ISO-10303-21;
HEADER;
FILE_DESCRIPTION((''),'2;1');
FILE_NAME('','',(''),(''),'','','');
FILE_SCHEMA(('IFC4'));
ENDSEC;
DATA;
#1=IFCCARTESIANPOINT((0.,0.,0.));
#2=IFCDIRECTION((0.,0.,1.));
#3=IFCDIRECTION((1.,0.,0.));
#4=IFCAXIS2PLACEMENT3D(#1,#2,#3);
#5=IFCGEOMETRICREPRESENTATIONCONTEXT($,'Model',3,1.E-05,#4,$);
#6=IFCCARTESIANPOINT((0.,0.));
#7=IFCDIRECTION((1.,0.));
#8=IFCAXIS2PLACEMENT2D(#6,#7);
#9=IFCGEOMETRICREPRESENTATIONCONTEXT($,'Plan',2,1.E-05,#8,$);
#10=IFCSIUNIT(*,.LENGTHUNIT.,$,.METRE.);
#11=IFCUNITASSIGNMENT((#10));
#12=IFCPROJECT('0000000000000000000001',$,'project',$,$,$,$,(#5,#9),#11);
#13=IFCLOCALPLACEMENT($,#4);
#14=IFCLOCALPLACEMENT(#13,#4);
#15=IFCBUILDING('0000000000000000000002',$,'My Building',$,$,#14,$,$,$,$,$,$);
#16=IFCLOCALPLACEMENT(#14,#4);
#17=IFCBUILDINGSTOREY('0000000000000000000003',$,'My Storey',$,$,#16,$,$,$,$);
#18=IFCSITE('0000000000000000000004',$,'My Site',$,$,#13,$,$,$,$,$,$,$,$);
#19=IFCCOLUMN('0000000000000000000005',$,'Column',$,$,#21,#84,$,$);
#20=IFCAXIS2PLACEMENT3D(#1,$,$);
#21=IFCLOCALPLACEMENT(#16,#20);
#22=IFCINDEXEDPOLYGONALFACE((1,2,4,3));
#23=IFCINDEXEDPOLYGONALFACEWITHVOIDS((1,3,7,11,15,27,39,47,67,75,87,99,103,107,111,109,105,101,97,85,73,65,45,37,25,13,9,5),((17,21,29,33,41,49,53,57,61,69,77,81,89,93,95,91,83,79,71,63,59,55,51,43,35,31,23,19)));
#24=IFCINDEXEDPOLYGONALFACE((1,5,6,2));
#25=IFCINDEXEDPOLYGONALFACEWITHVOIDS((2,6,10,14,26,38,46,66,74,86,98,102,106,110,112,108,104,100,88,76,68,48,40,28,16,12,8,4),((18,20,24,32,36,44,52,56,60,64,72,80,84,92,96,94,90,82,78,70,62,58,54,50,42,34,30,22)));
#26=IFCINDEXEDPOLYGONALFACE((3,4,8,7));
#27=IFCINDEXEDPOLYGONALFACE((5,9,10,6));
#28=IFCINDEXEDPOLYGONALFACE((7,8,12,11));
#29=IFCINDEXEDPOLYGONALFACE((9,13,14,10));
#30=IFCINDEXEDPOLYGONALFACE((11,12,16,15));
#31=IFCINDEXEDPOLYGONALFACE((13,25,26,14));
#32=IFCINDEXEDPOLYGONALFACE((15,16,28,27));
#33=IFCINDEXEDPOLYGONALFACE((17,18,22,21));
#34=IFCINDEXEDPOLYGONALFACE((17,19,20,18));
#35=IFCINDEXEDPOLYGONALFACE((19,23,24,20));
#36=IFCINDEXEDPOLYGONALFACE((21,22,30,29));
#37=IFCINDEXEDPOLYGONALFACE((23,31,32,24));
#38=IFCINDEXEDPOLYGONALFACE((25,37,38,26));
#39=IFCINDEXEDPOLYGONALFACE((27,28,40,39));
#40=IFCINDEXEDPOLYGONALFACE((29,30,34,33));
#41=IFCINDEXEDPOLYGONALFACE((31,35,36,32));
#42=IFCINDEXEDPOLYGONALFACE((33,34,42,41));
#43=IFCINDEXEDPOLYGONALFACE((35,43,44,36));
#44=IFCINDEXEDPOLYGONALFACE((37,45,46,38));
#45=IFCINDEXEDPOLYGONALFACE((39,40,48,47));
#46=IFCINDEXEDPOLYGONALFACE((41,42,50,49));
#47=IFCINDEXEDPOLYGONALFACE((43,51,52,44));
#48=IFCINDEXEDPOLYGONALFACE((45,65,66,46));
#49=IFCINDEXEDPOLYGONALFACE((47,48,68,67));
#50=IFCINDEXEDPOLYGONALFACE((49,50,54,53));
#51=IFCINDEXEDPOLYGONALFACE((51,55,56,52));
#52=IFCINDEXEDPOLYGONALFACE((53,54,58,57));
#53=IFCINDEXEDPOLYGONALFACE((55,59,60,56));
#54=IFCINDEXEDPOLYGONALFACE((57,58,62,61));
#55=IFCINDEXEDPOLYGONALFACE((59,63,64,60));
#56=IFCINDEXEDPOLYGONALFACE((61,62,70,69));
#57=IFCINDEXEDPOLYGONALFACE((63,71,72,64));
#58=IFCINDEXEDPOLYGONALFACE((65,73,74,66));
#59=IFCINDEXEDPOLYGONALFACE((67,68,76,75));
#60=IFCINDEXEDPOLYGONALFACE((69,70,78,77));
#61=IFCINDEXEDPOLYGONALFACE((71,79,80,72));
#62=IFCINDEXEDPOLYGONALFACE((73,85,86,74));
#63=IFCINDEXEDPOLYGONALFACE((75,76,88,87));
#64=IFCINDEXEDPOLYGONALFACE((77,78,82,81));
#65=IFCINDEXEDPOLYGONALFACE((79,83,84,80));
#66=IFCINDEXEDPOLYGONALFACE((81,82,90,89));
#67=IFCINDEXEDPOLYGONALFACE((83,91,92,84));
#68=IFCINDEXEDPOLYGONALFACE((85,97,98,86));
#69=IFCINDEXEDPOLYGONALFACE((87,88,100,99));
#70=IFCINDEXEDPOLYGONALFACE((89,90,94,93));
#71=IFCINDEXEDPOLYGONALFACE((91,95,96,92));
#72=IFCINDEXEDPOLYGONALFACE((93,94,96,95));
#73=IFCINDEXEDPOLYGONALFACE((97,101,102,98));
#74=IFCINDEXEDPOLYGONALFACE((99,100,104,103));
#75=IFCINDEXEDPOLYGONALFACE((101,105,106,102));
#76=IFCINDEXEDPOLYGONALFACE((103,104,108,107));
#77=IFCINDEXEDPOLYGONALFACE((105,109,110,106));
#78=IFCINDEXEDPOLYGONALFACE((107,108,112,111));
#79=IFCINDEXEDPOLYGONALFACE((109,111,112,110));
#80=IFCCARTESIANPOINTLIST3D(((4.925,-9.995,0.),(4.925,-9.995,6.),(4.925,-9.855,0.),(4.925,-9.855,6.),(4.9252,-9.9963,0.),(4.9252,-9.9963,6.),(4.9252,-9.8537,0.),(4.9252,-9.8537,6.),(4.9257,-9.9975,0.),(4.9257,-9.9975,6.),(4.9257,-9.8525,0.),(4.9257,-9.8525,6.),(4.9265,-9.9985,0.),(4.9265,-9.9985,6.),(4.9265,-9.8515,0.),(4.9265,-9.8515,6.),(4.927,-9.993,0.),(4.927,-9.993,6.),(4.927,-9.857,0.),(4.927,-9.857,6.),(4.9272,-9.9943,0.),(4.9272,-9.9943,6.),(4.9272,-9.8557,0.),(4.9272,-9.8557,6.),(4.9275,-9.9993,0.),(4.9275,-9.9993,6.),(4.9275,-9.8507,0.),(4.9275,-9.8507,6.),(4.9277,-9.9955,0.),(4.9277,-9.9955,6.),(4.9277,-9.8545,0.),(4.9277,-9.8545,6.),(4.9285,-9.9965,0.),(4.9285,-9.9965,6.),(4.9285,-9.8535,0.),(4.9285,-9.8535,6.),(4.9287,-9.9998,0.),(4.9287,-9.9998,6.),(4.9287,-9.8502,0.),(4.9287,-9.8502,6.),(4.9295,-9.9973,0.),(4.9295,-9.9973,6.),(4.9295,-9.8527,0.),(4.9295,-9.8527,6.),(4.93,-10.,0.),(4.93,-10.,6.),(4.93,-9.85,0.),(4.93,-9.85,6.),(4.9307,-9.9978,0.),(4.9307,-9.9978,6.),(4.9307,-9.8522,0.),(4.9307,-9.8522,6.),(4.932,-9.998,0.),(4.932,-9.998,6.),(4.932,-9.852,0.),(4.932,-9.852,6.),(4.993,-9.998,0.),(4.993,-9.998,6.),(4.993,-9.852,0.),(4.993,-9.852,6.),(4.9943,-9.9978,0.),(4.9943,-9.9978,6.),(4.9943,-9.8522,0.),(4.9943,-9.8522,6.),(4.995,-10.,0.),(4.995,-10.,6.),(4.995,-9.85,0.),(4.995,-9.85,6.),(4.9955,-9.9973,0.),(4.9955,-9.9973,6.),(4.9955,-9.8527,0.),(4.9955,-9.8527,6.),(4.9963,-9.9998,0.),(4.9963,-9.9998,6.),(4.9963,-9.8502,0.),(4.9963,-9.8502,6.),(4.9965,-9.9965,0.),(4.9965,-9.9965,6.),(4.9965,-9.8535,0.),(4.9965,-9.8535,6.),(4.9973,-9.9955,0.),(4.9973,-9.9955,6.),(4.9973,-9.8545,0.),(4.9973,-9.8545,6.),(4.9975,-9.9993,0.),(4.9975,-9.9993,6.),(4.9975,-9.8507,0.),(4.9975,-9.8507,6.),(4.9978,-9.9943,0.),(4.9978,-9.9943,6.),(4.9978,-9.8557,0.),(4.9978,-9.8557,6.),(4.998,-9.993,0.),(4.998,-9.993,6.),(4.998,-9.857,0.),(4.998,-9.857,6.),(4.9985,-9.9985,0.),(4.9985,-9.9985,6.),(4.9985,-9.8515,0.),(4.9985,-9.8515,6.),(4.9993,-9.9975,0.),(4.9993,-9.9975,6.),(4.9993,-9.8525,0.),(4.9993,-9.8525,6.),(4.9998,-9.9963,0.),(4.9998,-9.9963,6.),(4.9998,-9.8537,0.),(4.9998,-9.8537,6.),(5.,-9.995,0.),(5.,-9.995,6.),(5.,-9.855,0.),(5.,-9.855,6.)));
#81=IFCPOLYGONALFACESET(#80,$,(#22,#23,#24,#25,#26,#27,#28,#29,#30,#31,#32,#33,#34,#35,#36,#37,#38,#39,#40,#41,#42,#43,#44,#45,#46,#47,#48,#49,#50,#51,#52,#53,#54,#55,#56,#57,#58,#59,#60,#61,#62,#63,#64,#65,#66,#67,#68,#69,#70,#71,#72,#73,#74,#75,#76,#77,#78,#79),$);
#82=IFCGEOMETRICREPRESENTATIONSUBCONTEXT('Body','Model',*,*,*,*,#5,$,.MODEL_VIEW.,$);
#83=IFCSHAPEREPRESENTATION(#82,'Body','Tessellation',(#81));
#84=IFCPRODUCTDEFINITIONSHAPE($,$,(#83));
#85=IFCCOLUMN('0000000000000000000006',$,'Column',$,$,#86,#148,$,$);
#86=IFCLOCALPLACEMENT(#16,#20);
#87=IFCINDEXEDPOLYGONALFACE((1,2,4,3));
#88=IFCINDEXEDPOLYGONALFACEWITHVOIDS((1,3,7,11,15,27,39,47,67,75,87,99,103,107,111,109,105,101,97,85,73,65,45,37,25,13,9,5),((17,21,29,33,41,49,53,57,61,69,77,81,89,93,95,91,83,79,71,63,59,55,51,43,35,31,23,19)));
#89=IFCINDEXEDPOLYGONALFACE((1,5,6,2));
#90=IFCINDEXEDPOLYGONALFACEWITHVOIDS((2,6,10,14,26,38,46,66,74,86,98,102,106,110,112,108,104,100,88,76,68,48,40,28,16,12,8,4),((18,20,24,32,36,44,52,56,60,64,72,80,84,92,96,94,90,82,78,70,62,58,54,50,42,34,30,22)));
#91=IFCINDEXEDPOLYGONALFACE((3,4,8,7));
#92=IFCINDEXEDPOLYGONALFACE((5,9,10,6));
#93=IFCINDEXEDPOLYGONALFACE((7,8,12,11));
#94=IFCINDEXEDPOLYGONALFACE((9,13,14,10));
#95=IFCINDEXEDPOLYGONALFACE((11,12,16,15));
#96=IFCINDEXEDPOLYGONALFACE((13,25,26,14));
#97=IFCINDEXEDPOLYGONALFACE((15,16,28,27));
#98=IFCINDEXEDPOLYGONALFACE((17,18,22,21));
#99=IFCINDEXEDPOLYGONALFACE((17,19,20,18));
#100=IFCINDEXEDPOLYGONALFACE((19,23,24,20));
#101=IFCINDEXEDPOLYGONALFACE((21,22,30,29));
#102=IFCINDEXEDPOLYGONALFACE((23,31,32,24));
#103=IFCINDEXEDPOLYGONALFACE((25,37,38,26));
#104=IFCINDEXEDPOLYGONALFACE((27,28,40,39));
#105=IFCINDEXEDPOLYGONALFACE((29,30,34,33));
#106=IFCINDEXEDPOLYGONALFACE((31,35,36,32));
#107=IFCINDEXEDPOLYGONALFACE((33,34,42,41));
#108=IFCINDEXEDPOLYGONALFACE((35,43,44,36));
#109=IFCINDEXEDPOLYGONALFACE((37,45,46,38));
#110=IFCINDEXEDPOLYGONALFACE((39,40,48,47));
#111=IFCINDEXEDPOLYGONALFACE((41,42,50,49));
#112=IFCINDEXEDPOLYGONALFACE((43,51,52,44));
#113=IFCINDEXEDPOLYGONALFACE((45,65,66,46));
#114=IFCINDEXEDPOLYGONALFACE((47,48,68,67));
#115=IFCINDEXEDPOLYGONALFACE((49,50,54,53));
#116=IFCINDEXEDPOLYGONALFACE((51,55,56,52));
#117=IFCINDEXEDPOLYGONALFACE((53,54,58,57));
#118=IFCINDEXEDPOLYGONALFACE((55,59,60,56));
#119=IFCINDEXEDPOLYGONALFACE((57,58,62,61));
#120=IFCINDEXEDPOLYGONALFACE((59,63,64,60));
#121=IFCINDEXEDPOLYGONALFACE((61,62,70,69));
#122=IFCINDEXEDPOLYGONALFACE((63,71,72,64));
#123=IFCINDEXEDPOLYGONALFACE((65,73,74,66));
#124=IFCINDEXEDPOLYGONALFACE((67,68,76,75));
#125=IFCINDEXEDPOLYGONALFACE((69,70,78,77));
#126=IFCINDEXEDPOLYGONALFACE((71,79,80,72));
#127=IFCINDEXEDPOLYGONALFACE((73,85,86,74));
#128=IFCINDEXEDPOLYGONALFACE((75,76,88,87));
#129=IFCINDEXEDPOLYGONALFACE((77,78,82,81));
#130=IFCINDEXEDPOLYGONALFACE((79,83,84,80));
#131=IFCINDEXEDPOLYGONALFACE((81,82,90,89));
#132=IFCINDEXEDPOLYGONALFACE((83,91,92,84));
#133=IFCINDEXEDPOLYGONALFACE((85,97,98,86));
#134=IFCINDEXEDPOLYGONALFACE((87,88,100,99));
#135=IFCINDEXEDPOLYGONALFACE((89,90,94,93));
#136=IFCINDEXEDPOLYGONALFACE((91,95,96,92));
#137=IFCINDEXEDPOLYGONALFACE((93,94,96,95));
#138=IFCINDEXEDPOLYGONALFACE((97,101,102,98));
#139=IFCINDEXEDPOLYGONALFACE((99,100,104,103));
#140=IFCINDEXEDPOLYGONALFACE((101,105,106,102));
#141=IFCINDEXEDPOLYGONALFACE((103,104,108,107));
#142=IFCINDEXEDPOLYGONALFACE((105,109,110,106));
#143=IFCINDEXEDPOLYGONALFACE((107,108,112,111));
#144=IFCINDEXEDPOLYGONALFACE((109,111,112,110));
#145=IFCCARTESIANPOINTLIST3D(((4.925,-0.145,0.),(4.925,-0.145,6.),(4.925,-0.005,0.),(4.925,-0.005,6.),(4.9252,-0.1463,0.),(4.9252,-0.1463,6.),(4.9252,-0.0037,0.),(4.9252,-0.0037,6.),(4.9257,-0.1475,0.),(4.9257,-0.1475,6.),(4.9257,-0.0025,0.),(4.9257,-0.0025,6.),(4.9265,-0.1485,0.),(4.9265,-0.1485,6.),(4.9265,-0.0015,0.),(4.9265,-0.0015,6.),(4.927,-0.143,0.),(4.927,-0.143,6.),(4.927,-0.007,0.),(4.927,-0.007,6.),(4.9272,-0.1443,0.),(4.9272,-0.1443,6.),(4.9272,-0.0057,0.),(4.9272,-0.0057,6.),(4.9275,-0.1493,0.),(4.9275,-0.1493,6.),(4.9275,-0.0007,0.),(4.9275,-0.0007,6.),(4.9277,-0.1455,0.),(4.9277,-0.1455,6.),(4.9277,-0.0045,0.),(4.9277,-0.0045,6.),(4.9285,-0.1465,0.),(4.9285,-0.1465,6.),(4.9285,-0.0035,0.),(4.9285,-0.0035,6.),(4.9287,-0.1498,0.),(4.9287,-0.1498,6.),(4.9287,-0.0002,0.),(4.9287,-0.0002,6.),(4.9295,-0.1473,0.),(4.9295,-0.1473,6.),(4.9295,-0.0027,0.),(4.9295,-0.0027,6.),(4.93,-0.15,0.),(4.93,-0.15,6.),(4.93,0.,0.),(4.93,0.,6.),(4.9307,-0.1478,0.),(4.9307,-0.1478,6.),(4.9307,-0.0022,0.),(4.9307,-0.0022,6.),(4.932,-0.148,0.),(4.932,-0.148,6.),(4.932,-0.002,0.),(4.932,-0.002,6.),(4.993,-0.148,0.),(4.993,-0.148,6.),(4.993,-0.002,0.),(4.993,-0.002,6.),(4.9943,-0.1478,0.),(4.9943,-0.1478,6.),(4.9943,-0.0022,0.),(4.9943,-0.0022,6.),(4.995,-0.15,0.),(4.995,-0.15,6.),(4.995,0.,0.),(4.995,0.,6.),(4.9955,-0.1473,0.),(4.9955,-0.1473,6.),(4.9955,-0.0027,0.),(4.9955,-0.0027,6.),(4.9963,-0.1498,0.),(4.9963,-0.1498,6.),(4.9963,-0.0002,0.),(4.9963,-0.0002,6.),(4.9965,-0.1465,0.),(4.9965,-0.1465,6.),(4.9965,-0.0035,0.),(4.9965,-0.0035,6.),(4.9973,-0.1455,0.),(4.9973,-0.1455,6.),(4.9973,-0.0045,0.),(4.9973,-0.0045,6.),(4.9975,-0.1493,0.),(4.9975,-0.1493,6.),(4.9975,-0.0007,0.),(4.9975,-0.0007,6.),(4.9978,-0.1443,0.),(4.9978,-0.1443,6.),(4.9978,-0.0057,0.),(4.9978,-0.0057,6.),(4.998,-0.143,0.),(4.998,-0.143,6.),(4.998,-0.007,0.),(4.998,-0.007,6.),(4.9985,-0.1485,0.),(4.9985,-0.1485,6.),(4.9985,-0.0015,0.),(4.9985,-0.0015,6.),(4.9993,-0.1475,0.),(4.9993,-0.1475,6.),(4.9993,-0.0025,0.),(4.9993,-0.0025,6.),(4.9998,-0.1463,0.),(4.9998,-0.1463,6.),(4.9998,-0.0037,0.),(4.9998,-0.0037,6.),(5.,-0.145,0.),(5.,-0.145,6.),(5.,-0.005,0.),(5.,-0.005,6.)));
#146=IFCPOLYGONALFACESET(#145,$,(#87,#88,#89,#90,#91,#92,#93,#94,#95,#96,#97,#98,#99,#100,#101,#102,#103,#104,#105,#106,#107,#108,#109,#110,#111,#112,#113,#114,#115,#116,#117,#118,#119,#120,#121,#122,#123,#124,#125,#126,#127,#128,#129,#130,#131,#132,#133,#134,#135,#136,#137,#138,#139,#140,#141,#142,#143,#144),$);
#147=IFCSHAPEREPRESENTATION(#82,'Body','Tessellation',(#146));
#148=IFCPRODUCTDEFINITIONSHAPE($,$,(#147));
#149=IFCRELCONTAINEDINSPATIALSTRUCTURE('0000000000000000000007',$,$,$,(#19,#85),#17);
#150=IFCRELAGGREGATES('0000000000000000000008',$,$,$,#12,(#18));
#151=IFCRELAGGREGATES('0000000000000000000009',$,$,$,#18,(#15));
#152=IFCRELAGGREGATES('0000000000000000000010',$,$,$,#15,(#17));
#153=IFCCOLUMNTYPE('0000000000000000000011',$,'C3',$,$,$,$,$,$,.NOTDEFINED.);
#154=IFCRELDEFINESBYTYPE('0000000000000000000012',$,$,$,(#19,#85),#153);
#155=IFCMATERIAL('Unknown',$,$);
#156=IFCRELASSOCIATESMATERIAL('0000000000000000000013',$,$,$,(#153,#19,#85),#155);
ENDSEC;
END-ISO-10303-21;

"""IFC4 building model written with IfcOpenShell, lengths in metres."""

from ifc_helpers import new_model, si_unit, frame, origin_with_axes, origin_2d_with_axis, place, context, subcontext, project, spatial, hollow_rectangle, extrude, material, material_profile, profile_set, profile_usage, type_object, element, save


model = new_model("IFC4")

# Units and contexts
model_context = context("Model", 3, precision=1e-05, world=origin_with_axes())
plan_context = context("Plan", 2, precision=1e-05, world=origin_2d_with_axis())
body_context = subcontext(model_context, "Body", "Model", "MODEL_VIEW")
ifc_project = project(units=[si_unit("LENGTHUNIT", "METRE")], contexts=[model_context, plan_context])

# Site, building, storey
site_placement = place(None, origin_with_axes())
site = spatial("IfcSite", under=ifc_project, at=site_placement, Name="My Site")
building_placement = place(site_placement, origin_with_axes())
building = spatial("IfcBuilding", under=site, at=building_placement, Name="My Building")
storey_placement = place(building_placement, origin_with_axes())
storey = spatial("IfcBuildingStorey", under=building, at=storey_placement, Name="My Storey")

# Columns
ifc_material = material(Name="Unknown")
ifc_material_profile_1 = material_profile(ifc_material, hollow_rectangle(XDim=0.075, YDim=0.15, WallThickness=0.002, InnerFilletRadius=0.005, OuterFilletRadius=0.005))
ifc_profile_set_1 = profile_set([ifc_material_profile_1])
column_type = type_object("IfcColumnType", Name="C3", PredefinedType="NOTDEFINED", material=ifc_profile_set_1)
ifc_profile_usage_1 = profile_usage(ifc_profile_set_1, cardinal=5)
column_1_placement = place(storey_placement, frame((4.9625, -9.925, 0.0), z_axis=(0.0, 0.0, 1.0), x_axis=(1.0, 0.0, 0.0)))
element("IfcColumn", 1, at=column_1_placement, inside=storey, type_object=column_type, material=ifc_profile_usage_1, Name="Column", context=body_context, shape_type="SweptSolid", body=[
    extrude(hollow_rectangle(XDim=0.075, YDim=0.15, WallThickness=0.002, InnerFilletRadius=0.005, OuterFilletRadius=0.005), origin_with_axes(), (0.0, 0.0, 1.0), 6.0),
])
ifc_profile_usage_2 = profile_usage(ifc_profile_set_1, cardinal=5)
column_2_placement = place(storey_placement, frame((4.9625, -0.075, 0.0), z_axis=(0.0, 0.0, 1.0), x_axis=(1.0, 0.0, 0.0)))
element("IfcColumn", 2, at=column_2_placement, inside=storey, type_object=column_type, material=ifc_profile_usage_2, Name="Column", context=body_context, shape_type="SweptSolid", body=[
    extrude(hollow_rectangle(XDim=0.075, YDim=0.15, WallThickness=0.002, InnerFilletRadius=0.005, OuterFilletRadius=0.005), origin_with_axes(), (0.0, 0.0, 1.0), 6.0),
])

save(model, "model.ifc")
